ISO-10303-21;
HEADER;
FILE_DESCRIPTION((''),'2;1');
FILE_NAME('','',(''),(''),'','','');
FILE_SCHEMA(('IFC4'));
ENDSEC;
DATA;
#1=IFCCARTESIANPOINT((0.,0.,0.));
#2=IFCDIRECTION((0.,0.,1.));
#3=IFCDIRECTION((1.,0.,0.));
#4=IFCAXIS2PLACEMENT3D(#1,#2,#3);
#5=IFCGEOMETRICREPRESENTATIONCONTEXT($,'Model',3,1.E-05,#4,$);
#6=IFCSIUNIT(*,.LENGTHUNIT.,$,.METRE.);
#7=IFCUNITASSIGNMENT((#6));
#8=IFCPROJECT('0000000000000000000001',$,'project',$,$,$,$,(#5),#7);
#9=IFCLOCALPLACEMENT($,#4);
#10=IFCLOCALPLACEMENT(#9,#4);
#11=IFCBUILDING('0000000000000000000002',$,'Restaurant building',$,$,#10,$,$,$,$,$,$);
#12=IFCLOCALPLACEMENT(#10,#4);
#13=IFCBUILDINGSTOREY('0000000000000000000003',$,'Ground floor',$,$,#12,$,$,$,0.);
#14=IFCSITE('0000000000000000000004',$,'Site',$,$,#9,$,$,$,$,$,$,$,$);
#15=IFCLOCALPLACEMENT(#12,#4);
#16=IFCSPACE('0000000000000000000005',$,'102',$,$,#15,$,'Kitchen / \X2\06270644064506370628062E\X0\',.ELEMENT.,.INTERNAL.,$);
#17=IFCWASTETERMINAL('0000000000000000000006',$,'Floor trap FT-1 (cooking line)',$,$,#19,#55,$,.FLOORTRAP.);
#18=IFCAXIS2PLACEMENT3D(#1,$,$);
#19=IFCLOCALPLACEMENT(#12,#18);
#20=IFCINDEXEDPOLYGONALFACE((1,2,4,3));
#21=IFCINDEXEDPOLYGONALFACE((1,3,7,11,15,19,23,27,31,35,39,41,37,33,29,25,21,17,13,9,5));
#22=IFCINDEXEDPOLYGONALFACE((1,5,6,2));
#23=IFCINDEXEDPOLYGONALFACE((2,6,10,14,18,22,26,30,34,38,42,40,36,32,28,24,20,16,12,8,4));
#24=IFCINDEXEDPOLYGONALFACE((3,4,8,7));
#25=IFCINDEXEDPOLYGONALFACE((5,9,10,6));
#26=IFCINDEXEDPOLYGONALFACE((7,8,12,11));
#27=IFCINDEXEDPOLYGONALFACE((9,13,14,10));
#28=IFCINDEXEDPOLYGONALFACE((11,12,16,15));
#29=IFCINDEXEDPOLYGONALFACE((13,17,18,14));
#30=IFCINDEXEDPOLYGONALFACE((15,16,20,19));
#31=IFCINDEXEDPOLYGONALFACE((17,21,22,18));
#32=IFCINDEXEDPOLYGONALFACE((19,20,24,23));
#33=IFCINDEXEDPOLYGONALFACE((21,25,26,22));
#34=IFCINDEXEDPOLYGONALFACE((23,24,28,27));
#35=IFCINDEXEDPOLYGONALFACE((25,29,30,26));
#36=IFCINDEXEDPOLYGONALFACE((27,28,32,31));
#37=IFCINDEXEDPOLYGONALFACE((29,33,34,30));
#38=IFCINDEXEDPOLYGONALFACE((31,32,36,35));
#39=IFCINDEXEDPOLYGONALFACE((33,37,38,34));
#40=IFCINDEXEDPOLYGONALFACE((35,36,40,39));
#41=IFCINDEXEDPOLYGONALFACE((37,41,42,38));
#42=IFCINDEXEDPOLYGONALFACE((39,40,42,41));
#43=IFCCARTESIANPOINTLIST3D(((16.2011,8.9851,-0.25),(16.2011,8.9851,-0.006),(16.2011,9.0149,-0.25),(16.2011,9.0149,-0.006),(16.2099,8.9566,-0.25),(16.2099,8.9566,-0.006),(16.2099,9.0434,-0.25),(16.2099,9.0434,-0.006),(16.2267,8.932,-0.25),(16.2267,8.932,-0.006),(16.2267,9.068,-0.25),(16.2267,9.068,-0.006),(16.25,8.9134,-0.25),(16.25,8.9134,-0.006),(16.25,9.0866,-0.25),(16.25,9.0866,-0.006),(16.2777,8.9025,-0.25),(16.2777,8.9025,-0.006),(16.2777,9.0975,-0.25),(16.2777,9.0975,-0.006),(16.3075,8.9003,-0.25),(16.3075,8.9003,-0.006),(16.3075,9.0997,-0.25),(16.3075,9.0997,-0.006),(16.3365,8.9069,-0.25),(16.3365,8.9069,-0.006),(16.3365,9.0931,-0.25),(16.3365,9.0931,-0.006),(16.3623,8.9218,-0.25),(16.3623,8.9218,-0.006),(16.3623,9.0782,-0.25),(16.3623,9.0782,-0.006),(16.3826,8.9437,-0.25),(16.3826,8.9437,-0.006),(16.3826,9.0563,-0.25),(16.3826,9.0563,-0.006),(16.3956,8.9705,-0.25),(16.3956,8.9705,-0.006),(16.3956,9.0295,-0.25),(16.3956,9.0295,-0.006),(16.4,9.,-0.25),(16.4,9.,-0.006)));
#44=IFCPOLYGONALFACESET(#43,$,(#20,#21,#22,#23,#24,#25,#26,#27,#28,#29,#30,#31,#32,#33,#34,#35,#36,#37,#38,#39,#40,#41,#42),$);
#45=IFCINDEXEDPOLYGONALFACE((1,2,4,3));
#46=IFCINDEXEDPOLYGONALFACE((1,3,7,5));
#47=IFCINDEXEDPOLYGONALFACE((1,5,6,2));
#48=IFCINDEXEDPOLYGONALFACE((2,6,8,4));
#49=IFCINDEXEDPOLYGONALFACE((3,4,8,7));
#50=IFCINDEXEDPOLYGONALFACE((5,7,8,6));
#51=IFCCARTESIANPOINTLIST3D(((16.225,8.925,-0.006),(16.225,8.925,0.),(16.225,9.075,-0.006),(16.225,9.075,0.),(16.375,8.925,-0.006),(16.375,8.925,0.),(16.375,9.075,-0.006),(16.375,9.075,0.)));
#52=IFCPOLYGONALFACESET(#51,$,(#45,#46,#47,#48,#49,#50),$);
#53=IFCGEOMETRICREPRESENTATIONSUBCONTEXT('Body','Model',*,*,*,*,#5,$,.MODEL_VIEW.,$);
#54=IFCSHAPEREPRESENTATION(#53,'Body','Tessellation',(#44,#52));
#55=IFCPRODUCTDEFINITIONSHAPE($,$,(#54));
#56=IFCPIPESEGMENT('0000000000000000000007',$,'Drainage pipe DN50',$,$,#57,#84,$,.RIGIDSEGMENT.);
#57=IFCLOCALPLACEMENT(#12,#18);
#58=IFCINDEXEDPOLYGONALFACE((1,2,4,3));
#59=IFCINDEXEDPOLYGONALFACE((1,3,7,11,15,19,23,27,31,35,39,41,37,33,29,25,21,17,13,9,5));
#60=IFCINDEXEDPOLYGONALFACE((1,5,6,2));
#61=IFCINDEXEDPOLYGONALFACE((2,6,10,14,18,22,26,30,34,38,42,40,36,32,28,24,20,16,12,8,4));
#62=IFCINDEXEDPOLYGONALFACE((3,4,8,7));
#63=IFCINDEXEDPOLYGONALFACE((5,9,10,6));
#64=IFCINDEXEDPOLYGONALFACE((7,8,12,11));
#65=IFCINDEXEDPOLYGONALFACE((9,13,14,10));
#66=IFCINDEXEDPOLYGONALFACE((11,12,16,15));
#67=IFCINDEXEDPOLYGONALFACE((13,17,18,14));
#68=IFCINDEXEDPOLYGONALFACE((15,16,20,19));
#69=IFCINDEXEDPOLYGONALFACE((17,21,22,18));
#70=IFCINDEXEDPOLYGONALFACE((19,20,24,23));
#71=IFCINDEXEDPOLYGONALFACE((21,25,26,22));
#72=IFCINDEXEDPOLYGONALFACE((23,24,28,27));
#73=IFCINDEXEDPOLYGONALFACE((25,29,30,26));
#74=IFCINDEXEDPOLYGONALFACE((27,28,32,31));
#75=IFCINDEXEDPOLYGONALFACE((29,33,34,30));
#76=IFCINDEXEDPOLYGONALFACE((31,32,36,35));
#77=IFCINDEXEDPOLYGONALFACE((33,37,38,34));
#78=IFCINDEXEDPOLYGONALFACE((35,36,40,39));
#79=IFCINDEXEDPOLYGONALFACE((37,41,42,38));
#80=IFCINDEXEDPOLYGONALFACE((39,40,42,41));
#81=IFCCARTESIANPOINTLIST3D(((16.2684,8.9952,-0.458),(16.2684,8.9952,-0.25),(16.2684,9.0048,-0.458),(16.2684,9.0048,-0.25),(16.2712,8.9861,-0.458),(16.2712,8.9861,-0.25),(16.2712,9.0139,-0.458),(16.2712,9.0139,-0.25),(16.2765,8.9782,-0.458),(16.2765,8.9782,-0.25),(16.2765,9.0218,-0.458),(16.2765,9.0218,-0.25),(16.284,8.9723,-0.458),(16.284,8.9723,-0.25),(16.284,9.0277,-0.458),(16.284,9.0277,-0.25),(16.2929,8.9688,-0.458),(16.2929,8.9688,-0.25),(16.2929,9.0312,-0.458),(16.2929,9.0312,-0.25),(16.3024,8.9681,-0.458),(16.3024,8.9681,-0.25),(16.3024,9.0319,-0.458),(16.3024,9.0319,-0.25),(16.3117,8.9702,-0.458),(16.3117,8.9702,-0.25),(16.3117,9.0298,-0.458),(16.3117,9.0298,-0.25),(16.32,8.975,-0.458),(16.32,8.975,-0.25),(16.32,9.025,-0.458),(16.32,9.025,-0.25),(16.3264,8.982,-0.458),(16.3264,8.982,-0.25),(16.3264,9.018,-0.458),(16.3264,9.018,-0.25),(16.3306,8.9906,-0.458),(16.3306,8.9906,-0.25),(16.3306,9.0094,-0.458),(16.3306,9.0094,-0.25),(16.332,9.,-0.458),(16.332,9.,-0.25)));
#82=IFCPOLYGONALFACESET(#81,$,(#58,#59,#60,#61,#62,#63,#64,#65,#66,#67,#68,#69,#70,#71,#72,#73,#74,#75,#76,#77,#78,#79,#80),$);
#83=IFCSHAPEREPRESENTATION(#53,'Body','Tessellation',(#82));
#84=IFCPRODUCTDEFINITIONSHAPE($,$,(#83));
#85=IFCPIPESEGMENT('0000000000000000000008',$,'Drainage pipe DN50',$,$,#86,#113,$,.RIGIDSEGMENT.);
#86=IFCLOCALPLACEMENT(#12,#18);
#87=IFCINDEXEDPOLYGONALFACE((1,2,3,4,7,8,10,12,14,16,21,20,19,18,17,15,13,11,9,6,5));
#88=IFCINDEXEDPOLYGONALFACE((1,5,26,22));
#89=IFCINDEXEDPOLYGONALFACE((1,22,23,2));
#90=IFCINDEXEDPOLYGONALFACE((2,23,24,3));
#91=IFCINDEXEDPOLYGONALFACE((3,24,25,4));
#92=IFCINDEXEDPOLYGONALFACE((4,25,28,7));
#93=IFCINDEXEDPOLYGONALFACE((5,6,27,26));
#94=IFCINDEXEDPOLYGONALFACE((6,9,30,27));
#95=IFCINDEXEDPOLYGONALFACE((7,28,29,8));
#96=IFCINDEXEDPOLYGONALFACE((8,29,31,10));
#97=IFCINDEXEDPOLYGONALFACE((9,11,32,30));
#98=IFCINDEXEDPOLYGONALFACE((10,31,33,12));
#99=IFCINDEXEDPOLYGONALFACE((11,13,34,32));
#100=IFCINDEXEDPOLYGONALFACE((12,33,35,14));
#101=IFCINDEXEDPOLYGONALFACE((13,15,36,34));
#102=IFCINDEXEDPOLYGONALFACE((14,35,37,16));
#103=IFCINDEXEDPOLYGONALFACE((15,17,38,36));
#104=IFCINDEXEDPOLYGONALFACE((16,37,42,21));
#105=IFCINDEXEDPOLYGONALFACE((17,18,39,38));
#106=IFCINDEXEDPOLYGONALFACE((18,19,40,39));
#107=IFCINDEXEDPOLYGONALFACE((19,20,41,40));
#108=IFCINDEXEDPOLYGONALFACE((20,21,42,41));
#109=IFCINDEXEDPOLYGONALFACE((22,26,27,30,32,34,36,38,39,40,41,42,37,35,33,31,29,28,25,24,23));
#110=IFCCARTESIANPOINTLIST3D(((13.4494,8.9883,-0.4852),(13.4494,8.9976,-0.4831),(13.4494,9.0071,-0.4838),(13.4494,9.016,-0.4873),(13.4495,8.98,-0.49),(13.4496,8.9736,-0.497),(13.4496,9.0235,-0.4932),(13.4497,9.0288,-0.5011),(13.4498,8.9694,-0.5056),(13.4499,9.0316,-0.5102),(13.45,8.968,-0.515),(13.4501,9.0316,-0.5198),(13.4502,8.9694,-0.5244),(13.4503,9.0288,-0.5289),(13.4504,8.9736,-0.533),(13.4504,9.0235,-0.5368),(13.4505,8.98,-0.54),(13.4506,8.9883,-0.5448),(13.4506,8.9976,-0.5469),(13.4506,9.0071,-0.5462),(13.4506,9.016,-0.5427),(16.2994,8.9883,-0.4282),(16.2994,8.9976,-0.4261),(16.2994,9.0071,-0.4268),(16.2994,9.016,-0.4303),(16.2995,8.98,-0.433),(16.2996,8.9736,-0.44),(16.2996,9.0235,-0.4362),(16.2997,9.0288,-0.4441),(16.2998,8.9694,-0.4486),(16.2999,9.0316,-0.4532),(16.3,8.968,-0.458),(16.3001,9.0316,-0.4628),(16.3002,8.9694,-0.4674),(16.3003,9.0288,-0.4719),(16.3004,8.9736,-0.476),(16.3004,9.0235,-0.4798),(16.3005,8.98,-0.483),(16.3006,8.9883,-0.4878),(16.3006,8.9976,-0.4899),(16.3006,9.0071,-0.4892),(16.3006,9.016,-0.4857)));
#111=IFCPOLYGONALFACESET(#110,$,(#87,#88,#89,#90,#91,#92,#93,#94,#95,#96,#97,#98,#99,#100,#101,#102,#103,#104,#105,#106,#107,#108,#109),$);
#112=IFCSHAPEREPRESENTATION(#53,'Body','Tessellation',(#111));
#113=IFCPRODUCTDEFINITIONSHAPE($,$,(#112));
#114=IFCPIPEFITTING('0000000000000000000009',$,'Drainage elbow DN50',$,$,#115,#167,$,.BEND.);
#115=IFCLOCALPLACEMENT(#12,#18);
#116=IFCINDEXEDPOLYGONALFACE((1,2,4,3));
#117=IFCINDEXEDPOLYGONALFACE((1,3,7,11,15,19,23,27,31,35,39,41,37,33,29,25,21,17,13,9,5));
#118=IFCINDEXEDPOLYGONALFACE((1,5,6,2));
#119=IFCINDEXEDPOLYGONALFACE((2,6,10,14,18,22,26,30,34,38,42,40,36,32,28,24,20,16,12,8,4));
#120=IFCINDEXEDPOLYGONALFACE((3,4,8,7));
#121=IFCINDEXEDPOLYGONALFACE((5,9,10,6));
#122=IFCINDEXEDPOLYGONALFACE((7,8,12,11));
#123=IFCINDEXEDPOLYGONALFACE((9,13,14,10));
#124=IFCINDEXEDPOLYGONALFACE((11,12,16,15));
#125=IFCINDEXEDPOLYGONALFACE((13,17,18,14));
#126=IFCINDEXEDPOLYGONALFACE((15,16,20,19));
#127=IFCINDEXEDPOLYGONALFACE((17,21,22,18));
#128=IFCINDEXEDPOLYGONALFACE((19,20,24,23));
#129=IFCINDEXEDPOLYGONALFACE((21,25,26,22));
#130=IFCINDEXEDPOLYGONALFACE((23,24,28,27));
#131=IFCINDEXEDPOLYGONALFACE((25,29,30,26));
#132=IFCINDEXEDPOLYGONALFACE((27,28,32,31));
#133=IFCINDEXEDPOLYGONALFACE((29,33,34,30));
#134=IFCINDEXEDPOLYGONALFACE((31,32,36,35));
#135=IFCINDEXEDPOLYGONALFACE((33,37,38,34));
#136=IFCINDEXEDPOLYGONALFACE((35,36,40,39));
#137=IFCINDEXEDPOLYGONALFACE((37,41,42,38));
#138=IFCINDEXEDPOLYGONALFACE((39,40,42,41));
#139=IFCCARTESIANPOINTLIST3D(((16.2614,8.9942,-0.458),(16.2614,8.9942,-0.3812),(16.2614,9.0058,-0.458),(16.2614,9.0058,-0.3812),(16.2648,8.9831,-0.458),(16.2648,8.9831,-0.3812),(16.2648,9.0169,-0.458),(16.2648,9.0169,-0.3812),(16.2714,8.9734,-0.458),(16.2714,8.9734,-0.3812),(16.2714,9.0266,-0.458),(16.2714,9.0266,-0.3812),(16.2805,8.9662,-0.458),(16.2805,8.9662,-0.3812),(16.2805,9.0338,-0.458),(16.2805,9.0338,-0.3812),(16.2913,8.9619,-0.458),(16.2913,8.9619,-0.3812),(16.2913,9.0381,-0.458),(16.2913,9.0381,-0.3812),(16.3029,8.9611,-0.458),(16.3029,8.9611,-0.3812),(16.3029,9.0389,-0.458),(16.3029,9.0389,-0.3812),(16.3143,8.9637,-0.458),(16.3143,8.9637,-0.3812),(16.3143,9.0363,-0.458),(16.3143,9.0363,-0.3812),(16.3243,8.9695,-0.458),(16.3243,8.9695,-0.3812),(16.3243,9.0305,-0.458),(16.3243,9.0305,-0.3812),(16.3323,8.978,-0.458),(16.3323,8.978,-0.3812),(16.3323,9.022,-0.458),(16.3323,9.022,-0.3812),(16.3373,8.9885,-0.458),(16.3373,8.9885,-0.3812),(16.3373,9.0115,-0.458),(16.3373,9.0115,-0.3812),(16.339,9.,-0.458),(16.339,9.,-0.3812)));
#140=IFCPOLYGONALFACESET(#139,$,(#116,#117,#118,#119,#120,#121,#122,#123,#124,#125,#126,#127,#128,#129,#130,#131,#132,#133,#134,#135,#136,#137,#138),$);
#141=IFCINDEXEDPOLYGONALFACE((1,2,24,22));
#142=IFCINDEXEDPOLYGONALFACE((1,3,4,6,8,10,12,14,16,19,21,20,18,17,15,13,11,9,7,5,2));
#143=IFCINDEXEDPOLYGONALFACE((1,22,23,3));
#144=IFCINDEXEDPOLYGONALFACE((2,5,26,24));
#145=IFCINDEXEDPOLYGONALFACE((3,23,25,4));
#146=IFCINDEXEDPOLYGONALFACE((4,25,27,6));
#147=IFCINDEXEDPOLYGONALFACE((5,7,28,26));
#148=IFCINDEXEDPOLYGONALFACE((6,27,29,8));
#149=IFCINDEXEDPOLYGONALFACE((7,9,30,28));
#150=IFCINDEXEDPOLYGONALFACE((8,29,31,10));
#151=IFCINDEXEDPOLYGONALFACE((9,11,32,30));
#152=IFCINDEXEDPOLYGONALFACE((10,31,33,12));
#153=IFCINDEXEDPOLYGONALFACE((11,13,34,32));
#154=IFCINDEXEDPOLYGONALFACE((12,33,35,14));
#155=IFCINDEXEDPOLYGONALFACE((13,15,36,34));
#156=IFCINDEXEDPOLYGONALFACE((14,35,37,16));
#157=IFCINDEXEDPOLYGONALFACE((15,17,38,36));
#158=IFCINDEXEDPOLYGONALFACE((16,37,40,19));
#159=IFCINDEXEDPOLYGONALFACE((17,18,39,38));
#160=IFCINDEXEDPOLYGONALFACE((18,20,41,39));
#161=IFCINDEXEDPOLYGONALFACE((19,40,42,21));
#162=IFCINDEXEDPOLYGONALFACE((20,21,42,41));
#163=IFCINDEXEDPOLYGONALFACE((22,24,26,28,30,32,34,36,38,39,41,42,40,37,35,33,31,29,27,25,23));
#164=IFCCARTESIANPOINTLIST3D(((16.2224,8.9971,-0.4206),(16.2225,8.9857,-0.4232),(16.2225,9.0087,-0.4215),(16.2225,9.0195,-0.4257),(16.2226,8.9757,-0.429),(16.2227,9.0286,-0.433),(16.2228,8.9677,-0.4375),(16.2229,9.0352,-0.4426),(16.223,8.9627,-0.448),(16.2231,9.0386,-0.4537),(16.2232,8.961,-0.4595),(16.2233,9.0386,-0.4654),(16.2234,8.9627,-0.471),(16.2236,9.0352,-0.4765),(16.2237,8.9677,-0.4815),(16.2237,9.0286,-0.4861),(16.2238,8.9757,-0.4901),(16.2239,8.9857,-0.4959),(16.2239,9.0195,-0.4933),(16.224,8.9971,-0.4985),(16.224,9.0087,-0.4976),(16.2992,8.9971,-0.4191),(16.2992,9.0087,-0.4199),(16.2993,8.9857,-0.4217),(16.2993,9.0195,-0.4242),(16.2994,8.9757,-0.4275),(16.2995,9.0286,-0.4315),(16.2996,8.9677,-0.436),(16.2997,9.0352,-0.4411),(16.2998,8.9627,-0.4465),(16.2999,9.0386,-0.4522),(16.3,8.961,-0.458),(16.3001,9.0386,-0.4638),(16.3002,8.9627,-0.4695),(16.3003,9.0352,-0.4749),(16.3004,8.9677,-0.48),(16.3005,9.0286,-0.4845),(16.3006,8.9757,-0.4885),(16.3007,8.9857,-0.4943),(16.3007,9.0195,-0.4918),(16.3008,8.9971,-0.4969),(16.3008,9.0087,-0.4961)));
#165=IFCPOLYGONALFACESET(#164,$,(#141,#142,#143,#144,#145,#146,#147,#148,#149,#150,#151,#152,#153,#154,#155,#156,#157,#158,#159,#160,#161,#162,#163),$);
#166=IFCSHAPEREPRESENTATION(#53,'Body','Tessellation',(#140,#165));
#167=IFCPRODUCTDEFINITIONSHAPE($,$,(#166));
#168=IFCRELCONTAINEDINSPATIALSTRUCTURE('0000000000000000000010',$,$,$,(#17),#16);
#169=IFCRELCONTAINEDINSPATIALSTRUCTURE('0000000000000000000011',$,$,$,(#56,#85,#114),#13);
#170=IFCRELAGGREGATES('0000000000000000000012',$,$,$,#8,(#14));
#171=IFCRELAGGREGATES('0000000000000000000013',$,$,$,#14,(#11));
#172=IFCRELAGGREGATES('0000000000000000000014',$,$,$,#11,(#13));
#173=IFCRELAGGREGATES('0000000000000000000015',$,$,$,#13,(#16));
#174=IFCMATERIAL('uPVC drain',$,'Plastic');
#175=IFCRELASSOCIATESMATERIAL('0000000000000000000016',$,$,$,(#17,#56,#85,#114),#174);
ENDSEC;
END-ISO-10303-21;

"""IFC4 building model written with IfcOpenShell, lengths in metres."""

from ifc_helpers import new_model, si_unit, frame, origin, origin_with_axes, origin_2d, place, context, subcontext, project, spatial, rectangle, circle, extrude, material, element, save


model = new_model("IFC4")

# Units and contexts
model_context = context("Model", 3, precision=1e-05, world=origin_with_axes())
body_context = subcontext(model_context, "Body", "Model", "MODEL_VIEW")
ifc_project = project(units=[si_unit("LENGTHUNIT", "METRE")], contexts=[model_context])

# Site, building, storey, space
site_placement = place(None, origin_with_axes())
site = spatial("IfcSite", under=ifc_project, at=site_placement, Name="Site")
building_placement = place(site_placement, origin_with_axes())
building = spatial("IfcBuilding", under=site, at=building_placement, Name="Restaurant building")
storey_placement = place(building_placement, origin_with_axes())
storey = spatial("IfcBuildingStorey", under=building, at=storey_placement, Name="Ground floor", Elevation=0.0)
space_placement = place(storey_placement, origin_with_axes())
space = spatial("IfcSpace", under=storey, at=space_placement, Name="102", LongName="Kitchen / المطبخ", CompositionType="ELEMENT", PredefinedType="INTERNAL")

# Waste terminal
ifc_material_1 = material(Name="uPVC drain", Category="Plastic")
waste_terminal_placement = place(storey_placement, frame((16.3, 9.0, 0.0)))
element("IfcWasteTerminal", 1, at=waste_terminal_placement, inside=space, material=ifc_material_1, Name="Floor trap FT-1 (cooking line)", PredefinedType="FLOORTRAP", context=body_context, shape_type="SweptSolid", body=[
    extrude(circle(Radius=0.1, at=origin_2d()), frame((0.0, 0.0, -0.25)), (0.0, 0.0, 1.0), 0.244),
    extrude(rectangle(XDim=0.15, YDim=0.15, at=origin_2d()), frame((0.0, 0.0, -0.006)), (0.0, 0.0, 1.0), 0.006),
])

# Pipe segments
pipe_segment_1_placement = place(storey_placement, frame((16.3, 9.0, -0.25)))
element("IfcPipeSegment", 2, at=pipe_segment_1_placement, inside=storey, material=ifc_material_1, Name="Drainage pipe DN50", PredefinedType="RIGIDSEGMENT", context=body_context, shape_type="SweptSolid", body=[
    extrude(circle(Radius=0.032, at=origin_2d()), frame((0.0, 0.0, 0.0), z_axis=(0.0, 0.0, -1.0), x_axis=(1.0, 0.0, 0.0)), (0.0, 0.0, 1.0), 0.208),
])
pipe_segment_2_placement = place(storey_placement, frame((16.3, 9.0, -0.458)))
element("IfcPipeSegment", 3, at=pipe_segment_2_placement, inside=storey, material=ifc_material_1, Name="Drainage pipe DN50", PredefinedType="RIGIDSEGMENT", context=body_context, shape_type="SweptSolid", body=[
    extrude(circle(Radius=0.032, at=origin_2d()), frame((0.0, 0.0, 0.0), z_axis=(-0.9998, 0.0, -0.019996), x_axis=(0.0, -1.0, 0.0)), (0.0, 0.0, 1.0), 2.8506),
])

# Pipe fitting
pipe_fitting_placement = place(storey_placement, frame((16.3, 9.0, -0.458)))
element("IfcPipeFitting", 4, at=pipe_fitting_placement, inside=storey, material=ifc_material_1, Name="Drainage elbow DN50", PredefinedType="BEND", context=body_context, shape_type="SweptSolid", body=[
    extrude(circle(Radius=0.039, at=origin_2d()), origin(), (0.0, 0.0, 1.0), 0.0768),
    extrude(circle(Radius=0.039, at=origin_2d()), frame((0.0, 0.0, 0.0), z_axis=(-0.9998, 0.0, -0.019996), x_axis=(0.0, -1.0, 0.0)), (0.0, 0.0, 1.0), 0.0768),
])

save(model, "model.ifc")
